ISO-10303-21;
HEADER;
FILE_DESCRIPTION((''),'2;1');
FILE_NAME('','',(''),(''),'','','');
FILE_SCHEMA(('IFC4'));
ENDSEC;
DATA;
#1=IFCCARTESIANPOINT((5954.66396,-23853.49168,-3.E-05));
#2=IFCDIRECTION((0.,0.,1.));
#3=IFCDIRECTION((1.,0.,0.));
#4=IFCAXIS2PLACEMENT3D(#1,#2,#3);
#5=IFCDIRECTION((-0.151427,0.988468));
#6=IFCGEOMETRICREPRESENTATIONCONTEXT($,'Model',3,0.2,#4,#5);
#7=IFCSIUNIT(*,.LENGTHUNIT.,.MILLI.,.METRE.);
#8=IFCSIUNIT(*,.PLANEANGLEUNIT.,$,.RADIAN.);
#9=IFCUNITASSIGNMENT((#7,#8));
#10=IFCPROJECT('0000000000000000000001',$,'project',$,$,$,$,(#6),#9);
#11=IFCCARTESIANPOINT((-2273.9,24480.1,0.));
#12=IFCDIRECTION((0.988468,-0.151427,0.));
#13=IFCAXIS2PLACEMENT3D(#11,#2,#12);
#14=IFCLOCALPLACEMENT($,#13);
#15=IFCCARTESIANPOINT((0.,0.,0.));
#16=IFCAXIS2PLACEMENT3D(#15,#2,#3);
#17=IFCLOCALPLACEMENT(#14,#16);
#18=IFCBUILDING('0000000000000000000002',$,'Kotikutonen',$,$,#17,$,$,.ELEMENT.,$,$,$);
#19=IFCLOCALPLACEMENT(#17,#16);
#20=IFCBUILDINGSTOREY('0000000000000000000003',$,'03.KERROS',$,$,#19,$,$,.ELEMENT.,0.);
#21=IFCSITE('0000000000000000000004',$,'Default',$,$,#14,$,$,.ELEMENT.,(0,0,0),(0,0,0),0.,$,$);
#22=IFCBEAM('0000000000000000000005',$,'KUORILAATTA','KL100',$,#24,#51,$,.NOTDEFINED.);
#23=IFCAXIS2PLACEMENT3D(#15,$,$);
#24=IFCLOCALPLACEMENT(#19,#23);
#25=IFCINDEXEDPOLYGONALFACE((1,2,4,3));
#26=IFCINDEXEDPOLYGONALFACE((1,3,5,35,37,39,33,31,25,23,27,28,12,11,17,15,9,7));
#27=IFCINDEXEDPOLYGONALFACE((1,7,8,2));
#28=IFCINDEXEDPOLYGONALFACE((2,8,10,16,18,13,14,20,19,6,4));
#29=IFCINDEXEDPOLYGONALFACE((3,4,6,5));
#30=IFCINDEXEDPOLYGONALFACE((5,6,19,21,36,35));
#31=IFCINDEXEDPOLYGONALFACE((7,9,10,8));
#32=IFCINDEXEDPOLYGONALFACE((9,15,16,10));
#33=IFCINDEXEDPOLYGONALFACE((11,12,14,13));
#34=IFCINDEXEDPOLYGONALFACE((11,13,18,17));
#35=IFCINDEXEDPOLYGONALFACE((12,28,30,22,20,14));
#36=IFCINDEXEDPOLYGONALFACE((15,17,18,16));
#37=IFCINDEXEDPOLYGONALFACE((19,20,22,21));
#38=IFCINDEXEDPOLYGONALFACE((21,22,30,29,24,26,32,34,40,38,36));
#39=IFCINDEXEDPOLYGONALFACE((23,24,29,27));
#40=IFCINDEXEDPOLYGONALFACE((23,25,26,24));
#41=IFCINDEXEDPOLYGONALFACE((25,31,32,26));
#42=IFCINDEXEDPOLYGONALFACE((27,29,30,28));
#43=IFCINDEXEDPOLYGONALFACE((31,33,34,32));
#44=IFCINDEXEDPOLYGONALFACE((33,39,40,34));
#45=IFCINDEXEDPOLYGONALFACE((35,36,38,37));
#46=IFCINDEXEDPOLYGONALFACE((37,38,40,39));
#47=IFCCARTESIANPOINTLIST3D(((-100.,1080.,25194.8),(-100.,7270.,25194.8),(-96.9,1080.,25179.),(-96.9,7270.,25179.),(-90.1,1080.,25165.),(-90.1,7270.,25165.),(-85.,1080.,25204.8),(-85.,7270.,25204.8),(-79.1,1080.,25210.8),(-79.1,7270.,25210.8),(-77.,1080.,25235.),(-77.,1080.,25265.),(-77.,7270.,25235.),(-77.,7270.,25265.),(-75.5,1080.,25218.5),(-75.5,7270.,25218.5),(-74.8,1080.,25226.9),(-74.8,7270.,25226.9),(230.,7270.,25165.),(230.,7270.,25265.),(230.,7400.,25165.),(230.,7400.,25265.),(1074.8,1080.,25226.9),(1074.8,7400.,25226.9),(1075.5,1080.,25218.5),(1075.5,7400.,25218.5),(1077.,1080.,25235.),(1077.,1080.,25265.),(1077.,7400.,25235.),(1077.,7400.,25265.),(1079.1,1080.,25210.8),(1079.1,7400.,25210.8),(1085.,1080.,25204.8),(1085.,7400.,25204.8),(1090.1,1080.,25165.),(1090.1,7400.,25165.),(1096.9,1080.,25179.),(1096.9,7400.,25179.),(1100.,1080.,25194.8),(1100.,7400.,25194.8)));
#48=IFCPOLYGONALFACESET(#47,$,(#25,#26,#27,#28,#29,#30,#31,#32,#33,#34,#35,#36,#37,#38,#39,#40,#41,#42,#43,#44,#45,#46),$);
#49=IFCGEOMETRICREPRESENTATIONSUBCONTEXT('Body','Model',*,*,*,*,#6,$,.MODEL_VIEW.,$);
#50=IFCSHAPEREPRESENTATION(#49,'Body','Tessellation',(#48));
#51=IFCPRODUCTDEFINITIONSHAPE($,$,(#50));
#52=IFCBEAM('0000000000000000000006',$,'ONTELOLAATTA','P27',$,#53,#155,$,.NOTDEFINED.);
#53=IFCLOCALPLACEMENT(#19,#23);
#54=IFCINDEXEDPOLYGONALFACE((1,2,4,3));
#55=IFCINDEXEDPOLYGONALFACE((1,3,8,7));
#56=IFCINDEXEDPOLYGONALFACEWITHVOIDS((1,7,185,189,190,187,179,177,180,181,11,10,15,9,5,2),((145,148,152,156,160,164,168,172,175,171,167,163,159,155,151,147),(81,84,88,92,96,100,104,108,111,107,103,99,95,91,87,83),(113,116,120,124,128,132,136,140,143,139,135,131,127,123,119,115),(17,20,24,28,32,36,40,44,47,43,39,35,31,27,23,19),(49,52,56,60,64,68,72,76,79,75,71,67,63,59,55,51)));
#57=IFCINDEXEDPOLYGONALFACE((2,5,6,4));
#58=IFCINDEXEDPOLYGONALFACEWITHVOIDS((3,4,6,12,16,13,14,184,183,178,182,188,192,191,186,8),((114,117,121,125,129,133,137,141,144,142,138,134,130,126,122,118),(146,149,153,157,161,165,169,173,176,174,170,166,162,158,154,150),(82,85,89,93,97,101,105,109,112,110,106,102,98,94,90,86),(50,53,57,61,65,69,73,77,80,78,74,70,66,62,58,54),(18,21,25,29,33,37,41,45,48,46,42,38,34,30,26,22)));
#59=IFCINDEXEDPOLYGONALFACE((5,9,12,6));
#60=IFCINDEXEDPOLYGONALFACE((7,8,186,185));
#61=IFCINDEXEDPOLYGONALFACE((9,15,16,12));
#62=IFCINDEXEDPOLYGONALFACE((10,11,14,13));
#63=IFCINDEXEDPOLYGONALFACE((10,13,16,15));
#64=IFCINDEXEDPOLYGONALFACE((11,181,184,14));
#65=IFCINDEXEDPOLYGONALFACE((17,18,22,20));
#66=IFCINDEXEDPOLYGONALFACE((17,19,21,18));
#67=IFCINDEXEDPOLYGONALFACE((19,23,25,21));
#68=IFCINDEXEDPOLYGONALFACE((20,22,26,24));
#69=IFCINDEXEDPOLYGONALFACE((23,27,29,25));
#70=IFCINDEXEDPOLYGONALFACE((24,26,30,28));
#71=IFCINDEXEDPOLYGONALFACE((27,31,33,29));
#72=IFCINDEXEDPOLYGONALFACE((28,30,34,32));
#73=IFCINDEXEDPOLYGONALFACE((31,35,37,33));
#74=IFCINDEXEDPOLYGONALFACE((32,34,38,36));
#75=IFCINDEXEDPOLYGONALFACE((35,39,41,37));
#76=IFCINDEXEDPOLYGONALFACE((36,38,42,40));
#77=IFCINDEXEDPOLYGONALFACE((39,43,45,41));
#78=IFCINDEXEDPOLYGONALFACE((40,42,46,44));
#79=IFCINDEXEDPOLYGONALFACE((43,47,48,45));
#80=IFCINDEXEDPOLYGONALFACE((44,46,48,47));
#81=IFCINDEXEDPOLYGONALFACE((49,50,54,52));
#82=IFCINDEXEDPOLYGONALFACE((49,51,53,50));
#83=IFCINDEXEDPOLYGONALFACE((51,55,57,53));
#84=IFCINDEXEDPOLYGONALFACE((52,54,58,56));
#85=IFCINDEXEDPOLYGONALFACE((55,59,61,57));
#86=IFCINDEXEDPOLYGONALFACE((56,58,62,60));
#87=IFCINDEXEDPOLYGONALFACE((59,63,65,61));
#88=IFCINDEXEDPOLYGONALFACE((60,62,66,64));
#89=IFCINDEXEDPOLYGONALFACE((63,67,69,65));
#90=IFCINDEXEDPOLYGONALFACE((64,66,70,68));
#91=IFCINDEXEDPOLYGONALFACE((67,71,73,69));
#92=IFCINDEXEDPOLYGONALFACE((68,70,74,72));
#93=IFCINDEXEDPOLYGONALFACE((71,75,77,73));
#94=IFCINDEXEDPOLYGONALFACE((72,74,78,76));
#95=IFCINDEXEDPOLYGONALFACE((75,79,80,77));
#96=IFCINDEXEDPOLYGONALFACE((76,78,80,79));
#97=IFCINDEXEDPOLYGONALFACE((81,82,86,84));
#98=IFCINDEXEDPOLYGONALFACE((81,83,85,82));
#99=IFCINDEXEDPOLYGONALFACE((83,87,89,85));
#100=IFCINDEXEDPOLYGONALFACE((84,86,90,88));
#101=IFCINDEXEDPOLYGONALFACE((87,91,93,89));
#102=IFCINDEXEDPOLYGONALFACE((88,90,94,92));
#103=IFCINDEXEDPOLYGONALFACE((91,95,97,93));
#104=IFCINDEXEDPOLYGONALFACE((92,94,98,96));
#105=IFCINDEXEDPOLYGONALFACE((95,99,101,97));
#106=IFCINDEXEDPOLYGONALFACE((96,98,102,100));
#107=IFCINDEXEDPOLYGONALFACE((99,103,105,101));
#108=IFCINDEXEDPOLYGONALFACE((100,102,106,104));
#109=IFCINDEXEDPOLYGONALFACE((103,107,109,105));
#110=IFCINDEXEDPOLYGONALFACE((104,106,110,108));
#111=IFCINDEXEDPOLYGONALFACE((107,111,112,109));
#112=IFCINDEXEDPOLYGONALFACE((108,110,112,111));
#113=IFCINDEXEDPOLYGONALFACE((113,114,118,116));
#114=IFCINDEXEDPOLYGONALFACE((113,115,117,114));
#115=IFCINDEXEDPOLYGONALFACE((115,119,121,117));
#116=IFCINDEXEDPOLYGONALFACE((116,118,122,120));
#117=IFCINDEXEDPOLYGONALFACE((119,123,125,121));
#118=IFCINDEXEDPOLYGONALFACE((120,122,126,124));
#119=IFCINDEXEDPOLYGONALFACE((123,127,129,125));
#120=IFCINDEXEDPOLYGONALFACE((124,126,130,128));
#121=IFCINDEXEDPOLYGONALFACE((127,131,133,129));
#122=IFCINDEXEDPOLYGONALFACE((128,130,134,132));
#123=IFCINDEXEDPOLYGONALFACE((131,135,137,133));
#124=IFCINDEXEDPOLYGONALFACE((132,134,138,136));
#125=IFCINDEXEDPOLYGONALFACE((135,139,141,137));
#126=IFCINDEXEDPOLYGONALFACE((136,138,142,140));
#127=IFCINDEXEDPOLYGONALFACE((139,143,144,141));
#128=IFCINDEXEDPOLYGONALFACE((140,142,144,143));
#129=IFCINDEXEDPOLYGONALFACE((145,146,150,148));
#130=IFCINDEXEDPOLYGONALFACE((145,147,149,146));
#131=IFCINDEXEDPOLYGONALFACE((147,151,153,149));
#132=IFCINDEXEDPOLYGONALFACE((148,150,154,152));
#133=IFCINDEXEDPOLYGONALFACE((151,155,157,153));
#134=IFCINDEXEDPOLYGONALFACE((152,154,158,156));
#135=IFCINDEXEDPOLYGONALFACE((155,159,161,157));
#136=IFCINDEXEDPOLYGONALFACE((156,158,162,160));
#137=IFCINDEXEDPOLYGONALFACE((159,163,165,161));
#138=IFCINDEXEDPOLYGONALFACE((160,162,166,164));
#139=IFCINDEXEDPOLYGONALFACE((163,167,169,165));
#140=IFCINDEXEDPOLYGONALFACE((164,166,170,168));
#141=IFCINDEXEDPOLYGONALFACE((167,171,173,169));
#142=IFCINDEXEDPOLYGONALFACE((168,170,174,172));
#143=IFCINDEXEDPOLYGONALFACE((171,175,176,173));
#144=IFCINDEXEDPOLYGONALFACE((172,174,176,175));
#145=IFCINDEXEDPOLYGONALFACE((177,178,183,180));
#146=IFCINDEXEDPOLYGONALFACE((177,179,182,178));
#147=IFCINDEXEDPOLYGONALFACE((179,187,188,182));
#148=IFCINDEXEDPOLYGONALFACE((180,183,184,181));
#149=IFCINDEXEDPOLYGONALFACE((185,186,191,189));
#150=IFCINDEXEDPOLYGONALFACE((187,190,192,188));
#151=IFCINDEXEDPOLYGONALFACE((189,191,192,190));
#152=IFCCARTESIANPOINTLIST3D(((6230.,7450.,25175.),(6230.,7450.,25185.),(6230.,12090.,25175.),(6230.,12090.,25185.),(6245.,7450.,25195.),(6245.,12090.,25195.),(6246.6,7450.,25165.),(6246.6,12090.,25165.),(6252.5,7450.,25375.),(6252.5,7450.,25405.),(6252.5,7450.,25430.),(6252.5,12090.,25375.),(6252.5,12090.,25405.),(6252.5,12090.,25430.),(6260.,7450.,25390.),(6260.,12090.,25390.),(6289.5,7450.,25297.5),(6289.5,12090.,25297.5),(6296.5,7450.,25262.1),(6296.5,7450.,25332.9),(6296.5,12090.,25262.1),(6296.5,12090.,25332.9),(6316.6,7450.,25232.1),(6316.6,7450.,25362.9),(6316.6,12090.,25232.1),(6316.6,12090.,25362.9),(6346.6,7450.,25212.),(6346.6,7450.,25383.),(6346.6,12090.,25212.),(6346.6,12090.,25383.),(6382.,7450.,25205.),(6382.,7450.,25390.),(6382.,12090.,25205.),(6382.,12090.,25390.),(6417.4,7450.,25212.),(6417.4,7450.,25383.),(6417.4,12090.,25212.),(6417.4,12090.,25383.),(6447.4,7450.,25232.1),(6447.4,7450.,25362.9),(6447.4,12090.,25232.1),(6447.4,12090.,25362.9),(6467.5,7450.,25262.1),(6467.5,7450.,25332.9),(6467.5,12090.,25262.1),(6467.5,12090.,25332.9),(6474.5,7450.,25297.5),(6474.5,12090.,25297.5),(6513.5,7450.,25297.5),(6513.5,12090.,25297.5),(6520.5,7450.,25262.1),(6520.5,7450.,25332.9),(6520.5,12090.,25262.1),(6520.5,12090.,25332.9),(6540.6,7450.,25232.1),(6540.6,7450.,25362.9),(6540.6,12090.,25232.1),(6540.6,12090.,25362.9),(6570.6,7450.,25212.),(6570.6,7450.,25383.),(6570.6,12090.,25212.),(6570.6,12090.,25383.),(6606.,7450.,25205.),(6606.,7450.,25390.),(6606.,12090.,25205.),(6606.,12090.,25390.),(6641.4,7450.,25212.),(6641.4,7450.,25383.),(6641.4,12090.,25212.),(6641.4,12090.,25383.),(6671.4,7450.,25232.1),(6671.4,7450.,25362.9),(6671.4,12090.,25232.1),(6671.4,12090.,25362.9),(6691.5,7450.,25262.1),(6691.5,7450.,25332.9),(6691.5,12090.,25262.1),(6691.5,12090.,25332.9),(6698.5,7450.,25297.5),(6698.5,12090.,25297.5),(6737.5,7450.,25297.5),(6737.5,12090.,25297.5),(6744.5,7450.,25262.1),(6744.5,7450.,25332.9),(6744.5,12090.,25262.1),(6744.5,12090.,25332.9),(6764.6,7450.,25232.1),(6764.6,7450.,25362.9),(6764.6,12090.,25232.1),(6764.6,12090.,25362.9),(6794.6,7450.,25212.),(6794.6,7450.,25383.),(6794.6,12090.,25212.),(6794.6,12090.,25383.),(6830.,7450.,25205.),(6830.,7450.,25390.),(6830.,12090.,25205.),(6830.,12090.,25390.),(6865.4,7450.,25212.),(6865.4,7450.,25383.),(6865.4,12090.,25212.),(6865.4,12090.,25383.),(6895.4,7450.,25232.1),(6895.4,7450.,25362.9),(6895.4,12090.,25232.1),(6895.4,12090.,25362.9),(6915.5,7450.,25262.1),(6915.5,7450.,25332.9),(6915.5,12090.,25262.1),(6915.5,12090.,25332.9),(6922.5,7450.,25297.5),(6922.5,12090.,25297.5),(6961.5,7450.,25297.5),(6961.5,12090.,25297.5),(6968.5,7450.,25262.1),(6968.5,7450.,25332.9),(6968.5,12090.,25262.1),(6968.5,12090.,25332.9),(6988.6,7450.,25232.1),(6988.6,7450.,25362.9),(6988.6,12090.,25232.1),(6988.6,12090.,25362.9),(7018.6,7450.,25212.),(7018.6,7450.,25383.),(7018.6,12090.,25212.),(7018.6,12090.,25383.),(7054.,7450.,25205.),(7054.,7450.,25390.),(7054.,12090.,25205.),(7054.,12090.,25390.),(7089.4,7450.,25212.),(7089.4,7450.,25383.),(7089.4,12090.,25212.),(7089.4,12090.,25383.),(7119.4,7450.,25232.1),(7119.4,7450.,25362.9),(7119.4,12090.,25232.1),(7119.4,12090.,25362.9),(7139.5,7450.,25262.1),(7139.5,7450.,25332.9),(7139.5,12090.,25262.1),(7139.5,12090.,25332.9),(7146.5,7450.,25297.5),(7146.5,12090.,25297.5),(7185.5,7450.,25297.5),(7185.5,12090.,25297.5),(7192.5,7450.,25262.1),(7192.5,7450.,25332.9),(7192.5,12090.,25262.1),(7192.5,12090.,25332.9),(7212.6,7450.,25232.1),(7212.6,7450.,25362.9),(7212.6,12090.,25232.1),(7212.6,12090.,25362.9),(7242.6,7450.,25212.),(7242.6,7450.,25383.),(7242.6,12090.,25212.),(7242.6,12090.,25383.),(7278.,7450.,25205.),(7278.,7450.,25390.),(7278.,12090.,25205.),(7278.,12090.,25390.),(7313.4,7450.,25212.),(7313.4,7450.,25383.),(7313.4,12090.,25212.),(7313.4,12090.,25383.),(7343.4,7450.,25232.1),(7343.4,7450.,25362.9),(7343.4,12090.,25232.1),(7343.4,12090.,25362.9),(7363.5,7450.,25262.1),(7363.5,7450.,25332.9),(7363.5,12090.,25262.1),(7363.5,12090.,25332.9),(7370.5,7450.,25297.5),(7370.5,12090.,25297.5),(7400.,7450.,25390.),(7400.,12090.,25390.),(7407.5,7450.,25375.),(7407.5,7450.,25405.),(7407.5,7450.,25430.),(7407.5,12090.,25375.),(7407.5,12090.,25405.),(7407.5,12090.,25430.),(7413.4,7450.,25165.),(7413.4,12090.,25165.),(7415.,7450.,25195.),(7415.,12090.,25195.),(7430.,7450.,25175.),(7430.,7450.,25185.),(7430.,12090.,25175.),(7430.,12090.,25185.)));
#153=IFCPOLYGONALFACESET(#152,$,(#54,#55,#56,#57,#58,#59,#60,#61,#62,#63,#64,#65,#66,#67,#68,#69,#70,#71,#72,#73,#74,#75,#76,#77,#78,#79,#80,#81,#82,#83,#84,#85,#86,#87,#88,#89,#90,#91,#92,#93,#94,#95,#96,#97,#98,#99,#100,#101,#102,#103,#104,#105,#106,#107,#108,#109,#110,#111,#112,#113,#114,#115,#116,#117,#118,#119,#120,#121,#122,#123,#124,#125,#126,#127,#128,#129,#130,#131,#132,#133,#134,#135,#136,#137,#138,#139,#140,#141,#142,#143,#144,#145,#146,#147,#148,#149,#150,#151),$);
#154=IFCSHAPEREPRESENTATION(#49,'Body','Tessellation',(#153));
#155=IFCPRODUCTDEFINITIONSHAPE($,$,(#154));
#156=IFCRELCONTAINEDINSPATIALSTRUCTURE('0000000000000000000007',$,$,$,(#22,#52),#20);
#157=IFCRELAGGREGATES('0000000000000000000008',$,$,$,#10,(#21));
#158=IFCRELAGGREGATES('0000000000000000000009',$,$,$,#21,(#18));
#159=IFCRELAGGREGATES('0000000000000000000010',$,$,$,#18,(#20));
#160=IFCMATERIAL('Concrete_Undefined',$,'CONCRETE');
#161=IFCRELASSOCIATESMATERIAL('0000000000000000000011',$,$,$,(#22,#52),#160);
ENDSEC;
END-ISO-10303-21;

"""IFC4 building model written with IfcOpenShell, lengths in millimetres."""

from ifc_helpers import new_model, si_unit, direction, frame, origin_with_axes, place, context, subcontext, project, spatial, line, indexed_curve, outline, extrude, material, element, save


model = new_model("IFC4")

# Units and contexts
model_context = context("Model", 3, precision=0.2, world=frame((5954.66396, -23853.49168, -3e-05), z_axis=(0.0, 0.0, 1.0), x_axis=(1.0, 0.0, 0.0)), true_north=direction((-0.151427, 0.988468)))
body_context = subcontext(model_context, "Body", "Model", "MODEL_VIEW")
ifc_project = project(units=[si_unit("LENGTHUNIT", "METRE", prefix="MILLI"), si_unit("PLANEANGLEUNIT", "RADIAN")], contexts=[model_context])

# Site, building, storey
site_placement = place(None, frame((-2273.9, 24480.1, 0.0), z_axis=(0.0, 0.0, 1.0), x_axis=(0.988468, -0.151427, 0.0)))
site = spatial("IfcSite", under=ifc_project, at=site_placement, Name="Default", CompositionType="ELEMENT", RefLatitude=(0, 0, 0), RefLongitude=(0, 0, 0), RefElevation=0.0)
building_placement = place(site_placement, origin_with_axes())
building = spatial("IfcBuilding", under=site, at=building_placement, Name="Kotikutonen", CompositionType="ELEMENT")
storey_placement = place(building_placement, origin_with_axes())
storey = spatial("IfcBuildingStorey", under=building, at=storey_placement, Name="03.KERROS", CompositionType="ELEMENT", Elevation=0.0)

# Beam, voiding feature
ifc_material_1 = material(Name="Concrete_Undefined", Category="CONCRETE")
beam_1_placement = place(storey_placement, frame((500.0, 7400.0, 25215.0), z_axis=(-1.0, 0.0, 0.0), x_axis=(0.0, -1.0, 0.0)))
beam_1 = element("IfcBeam", 1, at=beam_1_placement, inside=storey, material=ifc_material_1, Name="KUORILAATTA", Description="KL100", PredefinedType="NOTDEFINED", context=body_context, shape_type="SolidModel", body=[
    extrude(outline(indexed_curve([(-596.9, -36.0), (-590.1, -50.0), (590.1, -50.0), (596.9, -36.0), (600.0, -20.2), (585.0, -10.2), (579.1, -4.2), (575.5, 3.5), (574.8, 11.9), (577.0, 20.0), (577.0, 50.0), (-577.0, 50.0), (-577.0, 20.0), (-574.8, 11.9), (-575.5, 3.5), (-579.1, -4.2), (-585.0, -10.2), (-600.0, -20.2)], segments=[line(1, 2, 3, 4, 5, 6, 7, 8, 9, 10, 11, 12, 13, 14, 15, 16, 17, 18, 1)])), frame((0.0, 0.0, 0.0), z_axis=(-1.0, 0.0, 0.0), x_axis=(0.0, 0.0, 1.0)), (0.0, 0.0, -1.0), 6320.0),
])
voiding_feature_1_placement = place(beam_1_placement, frame((130.0, 0.0, 270.0), z_axis=(0.0, 1.0, 0.0), x_axis=(-1.0, 0.0, 0.0)))
element("IfcVoidingFeature", 2, at=voiding_feature_1_placement, cuts=beam_1, Name="Opening", PredefinedType="HOLE", context=body_context, shape_type="SolidModel", body=[
    extrude(outline(indexed_curve([(0.0, 0.0), (380.0, 0.0), (380.0, 580.0), (0.0, 580.0)], segments=[line(1, 2, 3, 4, 1)])), frame((0.0, 0.0, 125.0), z_axis=(0.0, 0.0, 1.0), x_axis=(1.0, 0.0, 0.0)), (0.0, 0.0, -1.0), 250.0),
])

# Beam
beam_2_placement = place(storey_placement, frame((6830.0, 12090.0, 25297.5), z_axis=(-1.0, 0.0, 0.0), x_axis=(0.0, -1.0, 0.0)))
element("IfcBeam", 3, at=beam_2_placement, inside=storey, material=ifc_material_1, Name="ONTELOLAATTA", Description="P27", PredefinedType="NOTDEFINED", context=body_context, shape_type="SolidModel", body=[
    extrude(outline(indexed_curve([(-600.0, -122.5), (-583.4, -132.5), (583.4, -132.5), (600.0, -122.5), (600.0, -112.5), (585.0, -102.5), (577.5, 77.5), (570.0, 92.5), (577.5, 107.5), (577.5, 132.5), (-577.5, 132.5), (-577.5, 107.5), (-570.0, 92.5), (-577.5, 77.5), (-585.0, -102.5), (-600.0, -112.5)], segments=[line(1, 2, 3, 4, 5, 6, 7, 8, 9, 10, 11, 12, 13, 14, 15, 16, 1)]), holes=[indexed_curve([(-448.0, -92.5), (-483.4, -85.5), (-513.4, -65.4), (-533.5, -35.4), (-540.5, 0.0), (-533.5, 35.4), (-513.4, 65.4), (-483.4, 85.5), (-448.0, 92.5), (-412.6, 85.5), (-382.6, 65.4), (-362.5, 35.4), (-355.5, 0.0), (-362.5, -35.4), (-382.6, -65.4), (-412.6, -85.5)], segments=[line(1, 2, 3, 4, 5, 6, 7, 8, 9, 10, 11, 12, 13, 14, 15, 16, 1)]), indexed_curve([(-224.0, -92.5), (-259.4, -85.5), (-289.4, -65.4), (-309.5, -35.4), (-316.5, 0.0), (-309.5, 35.4), (-289.4, 65.4), (-259.4, 85.5), (-224.0, 92.5), (-188.6, 85.5), (-158.6, 65.4), (-138.5, 35.4), (-131.5, 0.0), (-138.5, -35.4), (-158.6, -65.4), (-188.6, -85.5)], segments=[line(1, 2, 3, 4, 5, 6, 7, 8, 9, 10, 11, 12, 13, 14, 15, 16, 1)]), indexed_curve([(0.0, -92.5), (-35.4, -85.5), (-65.4, -65.4), (-85.5, -35.4), (-92.5, 0.0), (-85.5, 35.4), (-65.4, 65.4), (-35.4, 85.5), (0.0, 92.5), (35.4, 85.5), (65.4, 65.4), (85.5, 35.4), (92.5, 0.0), (85.5, -35.4), (65.4, -65.4), (35.4, -85.5)], segments=[line(1, 2, 3, 4, 5, 6, 7, 8, 9, 10, 11, 12, 13, 14, 15, 16, 1)]), indexed_curve([(224.0, -92.5), (188.6, -85.5), (158.6, -65.4), (138.5, -35.4), (131.5, 0.0), (138.5, 35.4), (158.6, 65.4), (188.6, 85.5), (224.0, 92.5), (259.4, 85.5), (289.4, 65.4), (309.5, 35.4), (316.5, 0.0), (309.5, -35.4), (289.4, -65.4), (259.4, -85.5)], segments=[line(1, 2, 3, 4, 5, 6, 7, 8, 9, 10, 11, 12, 13, 14, 15, 16, 1)]), indexed_curve([(448.0, -92.5), (412.6, -85.5), (382.6, -65.4), (362.5, -35.4), (355.5, 0.0), (362.5, 35.4), (382.6, 65.4), (412.6, 85.5), (448.0, 92.5), (483.4, 85.5), (513.4, 65.4), (533.5, 35.4), (540.5, 0.0), (533.5, -35.4), (513.4, -65.4), (483.4, -85.5)], segments=[line(1, 2, 3, 4, 5, 6, 7, 8, 9, 10, 11, 12, 13, 14, 15, 16, 1)])]), frame((0.0, 0.0, 0.0), z_axis=(-1.0, 0.0, 0.0), x_axis=(0.0, 0.0, 1.0)), (0.0, 0.0, -1.0), 4640.0),
])

save(model, "model.ifc")
